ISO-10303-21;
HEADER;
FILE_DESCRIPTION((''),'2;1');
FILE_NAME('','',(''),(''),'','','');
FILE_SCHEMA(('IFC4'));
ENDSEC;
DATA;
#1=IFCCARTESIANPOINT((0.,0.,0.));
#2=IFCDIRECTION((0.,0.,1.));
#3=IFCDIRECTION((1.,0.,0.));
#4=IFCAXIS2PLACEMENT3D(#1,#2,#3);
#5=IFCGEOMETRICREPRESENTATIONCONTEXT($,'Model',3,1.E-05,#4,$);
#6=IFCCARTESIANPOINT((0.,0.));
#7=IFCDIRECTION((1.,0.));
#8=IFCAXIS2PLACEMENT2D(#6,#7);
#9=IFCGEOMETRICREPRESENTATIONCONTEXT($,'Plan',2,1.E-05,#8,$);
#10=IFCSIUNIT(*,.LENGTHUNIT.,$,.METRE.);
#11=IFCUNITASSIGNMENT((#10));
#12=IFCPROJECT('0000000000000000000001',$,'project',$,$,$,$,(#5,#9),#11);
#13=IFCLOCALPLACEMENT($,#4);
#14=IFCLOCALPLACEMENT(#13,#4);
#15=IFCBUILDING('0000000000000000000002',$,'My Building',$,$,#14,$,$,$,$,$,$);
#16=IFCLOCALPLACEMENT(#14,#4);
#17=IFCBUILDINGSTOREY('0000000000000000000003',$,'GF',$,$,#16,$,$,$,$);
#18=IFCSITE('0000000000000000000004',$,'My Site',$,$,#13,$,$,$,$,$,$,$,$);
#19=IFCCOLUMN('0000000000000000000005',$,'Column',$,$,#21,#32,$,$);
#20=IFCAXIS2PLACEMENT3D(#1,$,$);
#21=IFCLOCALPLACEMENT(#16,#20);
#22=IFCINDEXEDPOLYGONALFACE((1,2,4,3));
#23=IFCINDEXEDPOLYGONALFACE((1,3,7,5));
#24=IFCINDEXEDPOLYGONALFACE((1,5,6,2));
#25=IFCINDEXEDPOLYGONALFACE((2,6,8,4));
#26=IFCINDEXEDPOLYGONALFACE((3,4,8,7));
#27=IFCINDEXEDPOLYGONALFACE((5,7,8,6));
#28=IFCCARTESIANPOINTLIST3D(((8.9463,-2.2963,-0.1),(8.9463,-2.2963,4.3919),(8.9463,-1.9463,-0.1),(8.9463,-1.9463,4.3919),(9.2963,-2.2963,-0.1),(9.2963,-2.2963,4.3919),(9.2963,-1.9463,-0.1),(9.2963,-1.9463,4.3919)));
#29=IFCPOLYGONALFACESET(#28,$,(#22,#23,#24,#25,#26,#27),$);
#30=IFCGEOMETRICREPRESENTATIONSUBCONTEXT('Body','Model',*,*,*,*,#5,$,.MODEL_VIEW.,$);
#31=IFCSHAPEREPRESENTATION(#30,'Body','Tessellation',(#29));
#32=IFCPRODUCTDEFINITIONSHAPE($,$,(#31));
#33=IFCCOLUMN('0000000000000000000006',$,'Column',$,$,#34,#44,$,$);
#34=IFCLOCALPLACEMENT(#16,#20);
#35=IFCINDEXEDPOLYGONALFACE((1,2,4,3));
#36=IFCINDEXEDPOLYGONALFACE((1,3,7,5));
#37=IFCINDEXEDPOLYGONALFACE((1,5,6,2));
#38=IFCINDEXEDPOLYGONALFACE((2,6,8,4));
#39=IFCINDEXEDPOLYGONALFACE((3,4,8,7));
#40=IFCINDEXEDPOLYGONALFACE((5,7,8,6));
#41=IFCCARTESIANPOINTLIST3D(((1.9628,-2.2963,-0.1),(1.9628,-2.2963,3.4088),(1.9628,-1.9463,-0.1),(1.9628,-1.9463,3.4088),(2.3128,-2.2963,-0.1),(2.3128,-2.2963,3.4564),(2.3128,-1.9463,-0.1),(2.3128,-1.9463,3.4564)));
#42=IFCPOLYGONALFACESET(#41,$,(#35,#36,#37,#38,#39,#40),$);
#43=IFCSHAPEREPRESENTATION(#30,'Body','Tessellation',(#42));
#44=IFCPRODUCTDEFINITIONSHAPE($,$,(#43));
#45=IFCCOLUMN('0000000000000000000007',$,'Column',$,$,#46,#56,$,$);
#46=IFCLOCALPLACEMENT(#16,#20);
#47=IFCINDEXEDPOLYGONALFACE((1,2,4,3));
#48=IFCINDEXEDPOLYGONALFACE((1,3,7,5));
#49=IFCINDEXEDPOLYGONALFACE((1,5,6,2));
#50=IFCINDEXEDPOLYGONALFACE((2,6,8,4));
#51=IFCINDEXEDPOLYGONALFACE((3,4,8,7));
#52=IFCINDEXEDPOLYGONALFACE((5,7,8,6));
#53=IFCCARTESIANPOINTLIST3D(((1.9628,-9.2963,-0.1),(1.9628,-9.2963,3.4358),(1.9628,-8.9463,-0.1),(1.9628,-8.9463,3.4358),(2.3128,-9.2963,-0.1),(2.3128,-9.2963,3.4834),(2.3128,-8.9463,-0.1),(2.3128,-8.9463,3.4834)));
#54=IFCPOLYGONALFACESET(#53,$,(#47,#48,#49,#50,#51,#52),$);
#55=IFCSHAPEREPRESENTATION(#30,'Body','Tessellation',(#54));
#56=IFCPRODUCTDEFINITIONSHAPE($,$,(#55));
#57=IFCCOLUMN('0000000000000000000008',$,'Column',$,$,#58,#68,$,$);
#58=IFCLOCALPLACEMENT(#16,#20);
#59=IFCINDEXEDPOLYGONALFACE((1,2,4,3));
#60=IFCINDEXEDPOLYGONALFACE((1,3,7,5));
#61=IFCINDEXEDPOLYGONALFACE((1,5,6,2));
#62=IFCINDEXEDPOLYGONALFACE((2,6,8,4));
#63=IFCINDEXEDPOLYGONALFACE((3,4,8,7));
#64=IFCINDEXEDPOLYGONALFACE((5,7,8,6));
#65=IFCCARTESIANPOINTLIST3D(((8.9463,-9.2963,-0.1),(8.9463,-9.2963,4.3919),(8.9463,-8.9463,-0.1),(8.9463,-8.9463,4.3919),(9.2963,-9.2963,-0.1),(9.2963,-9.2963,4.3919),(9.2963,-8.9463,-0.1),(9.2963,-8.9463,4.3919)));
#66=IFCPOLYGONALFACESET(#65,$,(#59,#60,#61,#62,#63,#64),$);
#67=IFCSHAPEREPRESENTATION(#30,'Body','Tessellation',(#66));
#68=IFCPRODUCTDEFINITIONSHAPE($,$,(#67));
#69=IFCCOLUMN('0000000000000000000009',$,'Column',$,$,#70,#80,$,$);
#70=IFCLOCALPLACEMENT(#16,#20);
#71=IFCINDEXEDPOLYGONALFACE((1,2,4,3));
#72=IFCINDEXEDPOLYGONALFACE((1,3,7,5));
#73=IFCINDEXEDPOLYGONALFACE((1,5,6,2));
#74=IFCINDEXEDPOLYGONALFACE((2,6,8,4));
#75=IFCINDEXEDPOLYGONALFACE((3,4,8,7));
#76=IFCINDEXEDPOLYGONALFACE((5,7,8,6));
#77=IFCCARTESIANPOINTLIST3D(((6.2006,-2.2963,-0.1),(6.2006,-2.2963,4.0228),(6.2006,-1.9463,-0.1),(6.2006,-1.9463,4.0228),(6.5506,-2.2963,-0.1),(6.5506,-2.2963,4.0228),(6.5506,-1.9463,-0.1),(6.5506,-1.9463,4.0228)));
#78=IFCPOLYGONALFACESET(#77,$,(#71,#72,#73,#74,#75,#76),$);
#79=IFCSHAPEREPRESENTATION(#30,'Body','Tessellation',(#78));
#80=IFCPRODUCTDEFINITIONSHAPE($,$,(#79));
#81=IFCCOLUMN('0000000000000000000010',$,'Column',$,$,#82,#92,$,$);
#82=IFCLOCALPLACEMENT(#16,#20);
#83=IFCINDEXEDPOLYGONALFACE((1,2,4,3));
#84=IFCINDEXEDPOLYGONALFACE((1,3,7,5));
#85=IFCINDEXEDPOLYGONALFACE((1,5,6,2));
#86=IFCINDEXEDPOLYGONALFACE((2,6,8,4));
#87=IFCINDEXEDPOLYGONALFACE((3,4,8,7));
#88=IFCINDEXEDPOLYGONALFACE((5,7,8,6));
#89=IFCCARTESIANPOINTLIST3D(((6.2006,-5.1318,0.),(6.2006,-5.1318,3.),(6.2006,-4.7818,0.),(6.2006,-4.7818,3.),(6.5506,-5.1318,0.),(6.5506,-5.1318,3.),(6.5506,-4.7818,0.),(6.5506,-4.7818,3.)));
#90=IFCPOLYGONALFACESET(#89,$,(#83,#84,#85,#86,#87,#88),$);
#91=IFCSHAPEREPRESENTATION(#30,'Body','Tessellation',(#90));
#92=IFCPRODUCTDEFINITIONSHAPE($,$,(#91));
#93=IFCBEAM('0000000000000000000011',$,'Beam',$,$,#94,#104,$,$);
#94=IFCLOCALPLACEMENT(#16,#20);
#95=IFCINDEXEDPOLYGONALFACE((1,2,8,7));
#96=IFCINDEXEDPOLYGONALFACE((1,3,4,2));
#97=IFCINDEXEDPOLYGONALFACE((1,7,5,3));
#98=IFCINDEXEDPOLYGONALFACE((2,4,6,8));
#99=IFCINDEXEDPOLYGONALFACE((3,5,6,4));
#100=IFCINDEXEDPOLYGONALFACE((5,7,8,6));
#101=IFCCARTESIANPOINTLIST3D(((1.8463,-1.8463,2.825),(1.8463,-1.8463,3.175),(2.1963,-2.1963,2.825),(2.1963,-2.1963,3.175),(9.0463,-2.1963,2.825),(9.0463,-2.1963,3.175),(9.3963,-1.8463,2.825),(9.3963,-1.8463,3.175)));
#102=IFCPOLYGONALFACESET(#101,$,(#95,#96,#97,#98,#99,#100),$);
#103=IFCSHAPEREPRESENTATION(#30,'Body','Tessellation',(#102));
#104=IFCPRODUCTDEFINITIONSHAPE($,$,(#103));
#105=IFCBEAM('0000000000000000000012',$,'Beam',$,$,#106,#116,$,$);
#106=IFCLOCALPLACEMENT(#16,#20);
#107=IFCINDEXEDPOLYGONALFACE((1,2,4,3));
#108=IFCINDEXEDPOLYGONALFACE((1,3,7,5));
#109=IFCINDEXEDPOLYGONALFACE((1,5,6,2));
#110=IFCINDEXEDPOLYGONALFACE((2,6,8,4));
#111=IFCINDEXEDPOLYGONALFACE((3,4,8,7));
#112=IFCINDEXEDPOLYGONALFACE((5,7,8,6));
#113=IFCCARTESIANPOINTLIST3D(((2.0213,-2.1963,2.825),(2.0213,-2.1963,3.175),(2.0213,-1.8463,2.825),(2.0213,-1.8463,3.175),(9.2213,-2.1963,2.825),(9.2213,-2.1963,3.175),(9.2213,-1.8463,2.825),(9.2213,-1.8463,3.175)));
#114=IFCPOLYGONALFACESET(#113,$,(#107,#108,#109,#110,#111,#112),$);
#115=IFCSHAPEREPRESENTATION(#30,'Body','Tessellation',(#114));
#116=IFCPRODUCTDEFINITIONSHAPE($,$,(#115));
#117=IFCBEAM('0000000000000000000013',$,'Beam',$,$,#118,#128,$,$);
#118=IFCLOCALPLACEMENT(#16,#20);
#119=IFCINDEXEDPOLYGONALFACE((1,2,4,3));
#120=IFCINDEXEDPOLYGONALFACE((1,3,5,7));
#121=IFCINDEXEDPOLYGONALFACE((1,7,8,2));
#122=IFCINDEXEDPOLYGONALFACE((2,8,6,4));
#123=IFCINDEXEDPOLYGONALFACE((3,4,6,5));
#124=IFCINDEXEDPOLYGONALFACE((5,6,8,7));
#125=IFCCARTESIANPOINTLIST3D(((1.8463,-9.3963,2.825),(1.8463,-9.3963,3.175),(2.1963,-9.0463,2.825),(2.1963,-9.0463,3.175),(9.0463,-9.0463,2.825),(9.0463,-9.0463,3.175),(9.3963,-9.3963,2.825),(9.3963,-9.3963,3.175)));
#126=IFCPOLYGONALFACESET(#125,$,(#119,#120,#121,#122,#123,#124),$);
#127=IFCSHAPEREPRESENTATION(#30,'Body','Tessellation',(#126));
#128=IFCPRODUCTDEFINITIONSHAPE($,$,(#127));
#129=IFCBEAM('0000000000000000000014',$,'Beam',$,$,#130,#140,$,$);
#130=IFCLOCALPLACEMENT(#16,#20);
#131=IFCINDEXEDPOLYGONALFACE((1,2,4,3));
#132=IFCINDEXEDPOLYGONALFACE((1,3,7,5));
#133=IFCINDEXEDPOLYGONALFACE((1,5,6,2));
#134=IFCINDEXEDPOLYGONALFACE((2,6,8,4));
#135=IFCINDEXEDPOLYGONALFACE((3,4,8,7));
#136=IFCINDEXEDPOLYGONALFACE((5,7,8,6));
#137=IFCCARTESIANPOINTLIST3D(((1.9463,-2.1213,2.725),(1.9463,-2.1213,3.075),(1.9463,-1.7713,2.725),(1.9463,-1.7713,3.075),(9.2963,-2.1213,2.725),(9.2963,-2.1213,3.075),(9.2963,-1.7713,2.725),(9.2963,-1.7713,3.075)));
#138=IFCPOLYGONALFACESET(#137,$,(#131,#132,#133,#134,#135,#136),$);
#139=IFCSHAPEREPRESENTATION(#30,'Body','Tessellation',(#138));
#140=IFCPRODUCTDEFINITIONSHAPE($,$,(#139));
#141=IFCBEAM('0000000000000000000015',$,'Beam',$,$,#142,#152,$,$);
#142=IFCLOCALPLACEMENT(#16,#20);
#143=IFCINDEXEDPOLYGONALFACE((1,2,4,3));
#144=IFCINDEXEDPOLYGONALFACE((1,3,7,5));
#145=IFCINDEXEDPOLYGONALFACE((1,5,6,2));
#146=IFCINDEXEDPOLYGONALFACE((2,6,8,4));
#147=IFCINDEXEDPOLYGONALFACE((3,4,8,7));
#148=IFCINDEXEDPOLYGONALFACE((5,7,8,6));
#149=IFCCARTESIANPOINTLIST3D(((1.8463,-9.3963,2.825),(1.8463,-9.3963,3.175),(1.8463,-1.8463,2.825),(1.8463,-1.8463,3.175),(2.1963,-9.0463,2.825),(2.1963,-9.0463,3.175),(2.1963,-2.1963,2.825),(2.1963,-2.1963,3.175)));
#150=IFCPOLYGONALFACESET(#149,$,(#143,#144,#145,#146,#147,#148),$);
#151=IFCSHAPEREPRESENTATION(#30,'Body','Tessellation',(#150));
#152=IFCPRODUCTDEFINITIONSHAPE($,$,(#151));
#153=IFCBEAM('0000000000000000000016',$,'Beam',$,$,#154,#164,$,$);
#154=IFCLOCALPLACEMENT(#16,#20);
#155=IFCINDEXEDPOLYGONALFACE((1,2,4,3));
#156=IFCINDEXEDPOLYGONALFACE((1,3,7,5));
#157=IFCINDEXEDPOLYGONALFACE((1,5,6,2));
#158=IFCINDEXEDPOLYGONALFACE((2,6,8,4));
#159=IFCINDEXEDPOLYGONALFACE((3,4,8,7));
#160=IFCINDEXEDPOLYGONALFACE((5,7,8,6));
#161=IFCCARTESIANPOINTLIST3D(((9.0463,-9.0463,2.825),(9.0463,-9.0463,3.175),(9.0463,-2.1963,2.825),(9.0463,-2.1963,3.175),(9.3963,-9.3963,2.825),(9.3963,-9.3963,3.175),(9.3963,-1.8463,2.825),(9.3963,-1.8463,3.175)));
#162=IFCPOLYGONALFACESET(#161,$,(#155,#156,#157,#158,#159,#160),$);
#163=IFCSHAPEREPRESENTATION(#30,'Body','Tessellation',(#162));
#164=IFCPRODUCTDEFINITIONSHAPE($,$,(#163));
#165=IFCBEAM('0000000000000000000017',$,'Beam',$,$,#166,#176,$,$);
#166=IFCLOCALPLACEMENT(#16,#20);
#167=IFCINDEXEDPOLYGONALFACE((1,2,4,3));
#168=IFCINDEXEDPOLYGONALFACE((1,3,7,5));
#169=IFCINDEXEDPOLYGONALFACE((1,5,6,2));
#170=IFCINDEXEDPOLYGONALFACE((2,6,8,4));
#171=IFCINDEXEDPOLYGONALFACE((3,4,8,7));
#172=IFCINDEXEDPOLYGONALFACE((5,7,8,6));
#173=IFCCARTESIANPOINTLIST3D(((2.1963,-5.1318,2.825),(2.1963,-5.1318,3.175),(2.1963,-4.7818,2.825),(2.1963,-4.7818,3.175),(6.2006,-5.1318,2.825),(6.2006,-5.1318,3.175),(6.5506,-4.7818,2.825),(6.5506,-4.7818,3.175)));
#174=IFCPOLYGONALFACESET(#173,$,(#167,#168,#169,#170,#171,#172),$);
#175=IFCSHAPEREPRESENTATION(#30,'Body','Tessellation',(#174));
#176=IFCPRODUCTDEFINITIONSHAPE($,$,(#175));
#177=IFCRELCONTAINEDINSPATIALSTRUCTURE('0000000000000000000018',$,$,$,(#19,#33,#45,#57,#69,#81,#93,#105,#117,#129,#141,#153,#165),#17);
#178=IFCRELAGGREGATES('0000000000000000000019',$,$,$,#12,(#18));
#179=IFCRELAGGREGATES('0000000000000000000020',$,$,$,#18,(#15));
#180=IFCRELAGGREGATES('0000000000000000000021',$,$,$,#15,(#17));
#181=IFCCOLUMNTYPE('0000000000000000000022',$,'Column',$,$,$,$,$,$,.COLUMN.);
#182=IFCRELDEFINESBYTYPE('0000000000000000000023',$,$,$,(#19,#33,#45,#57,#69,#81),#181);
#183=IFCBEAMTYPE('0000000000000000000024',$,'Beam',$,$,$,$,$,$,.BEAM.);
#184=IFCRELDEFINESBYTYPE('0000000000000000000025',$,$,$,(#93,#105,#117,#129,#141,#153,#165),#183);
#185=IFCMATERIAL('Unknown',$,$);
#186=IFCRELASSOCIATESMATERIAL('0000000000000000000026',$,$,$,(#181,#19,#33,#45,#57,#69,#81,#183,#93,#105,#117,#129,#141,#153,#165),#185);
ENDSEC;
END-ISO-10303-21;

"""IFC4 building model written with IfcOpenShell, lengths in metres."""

from ifc_helpers import new_model, si_unit, frame, origin_with_axes, origin_2d_with_axis, place, context, subcontext, project, spatial, rectangle, extrude, clip, halfspace, material, material_profile, profile_set, profile_usage, type_object, element, save


model = new_model("IFC4")

# Units and contexts
model_context = context("Model", 3, precision=1e-05, world=origin_with_axes())
plan_context = context("Plan", 2, precision=1e-05, world=origin_2d_with_axis())
body_context_1 = subcontext(model_context, "Body", "Model", "MODEL_VIEW")
ifc_project = project(units=[si_unit("LENGTHUNIT", "METRE")], contexts=[model_context, plan_context])

# Site, building, storey
site_placement = place(None, origin_with_axes())
site = spatial("IfcSite", under=ifc_project, at=site_placement, Name="My Site")
building_placement = place(site_placement, origin_with_axes())
building = spatial("IfcBuilding", under=site, at=building_placement, Name="My Building")
storey_placement = place(building_placement, origin_with_axes())
storey = spatial("IfcBuildingStorey", under=building, at=storey_placement, Name="GF")

# Columns
ifc_material = material(Name="Unknown")
ifc_material_profile_1 = material_profile(ifc_material, rectangle(XDim=0.35, YDim=0.35))
ifc_profile_set_1 = profile_set([ifc_material_profile_1])
ifc_profile_usage_1 = profile_usage(ifc_profile_set_1, cardinal=5)
column_type = type_object("IfcColumnType", Name="Column", PredefinedType="COLUMN", material=ifc_profile_set_1)
column_1_placement = place(storey_placement, frame((9.1213, -2.1213, -0.1), z_axis=(0.0, 0.0, 1.0), x_axis=(1.0, 0.0, 0.0)))
element("IfcColumn", 1, at=column_1_placement, inside=storey, type_object=column_type, material=ifc_profile_usage_1, Name="Column", context=body_context_1, shape_type="SweptSolid", body=[
    extrude(rectangle(XDim=0.35, YDim=0.35), origin_with_axes(), (0.0, 0.0, 1.0), 4.4919),
])
ifc_profile_usage_2 = profile_usage(ifc_profile_set_1, cardinal=5)
column_2_placement = place(storey_placement, frame((2.1378, -2.1213, -0.1), z_axis=(0.0, 0.0, 1.0), x_axis=(1.0, 0.0, 0.0)))
element("IfcColumn", 2, at=column_2_placement, inside=storey, type_object=column_type, material=ifc_profile_usage_2, Name="Column", context=body_context_1, shape_type="Clipping", body=[
    clip(extrude(rectangle(XDim=0.35, YDim=0.35), origin_with_axes(), (0.0, 0.0, 1.0), 3.8826), halfspace(frame((6.8081, 0.0, 4.4568), z_axis=(-0.134523, 0.0, 0.990911), x_axis=(0.0, 1.0, 0.0)), False)),
])
ifc_profile_usage_3 = profile_usage(ifc_profile_set_1, cardinal=5)
column_3_placement = place(storey_placement, frame((2.1378, -9.1213, -0.1), z_axis=(0.0, 0.0, 1.0), x_axis=(1.0, 0.0, 0.0)))
element("IfcColumn", 3, at=column_3_placement, inside=storey, type_object=column_type, material=ifc_profile_usage_3, Name="Column", context=body_context_1, shape_type="Clipping", body=[
    clip(extrude(rectangle(XDim=0.35, YDim=0.35), origin_with_axes(), (0.0, 0.0, 1.0), 3.9096), halfspace(frame((6.8081, 0.0, 4.4838), z_axis=(-0.134523, 0.0, 0.990911), x_axis=(0.0, 1.0, 0.0)), False)),
])
ifc_profile_usage_4 = profile_usage(ifc_profile_set_1, cardinal=5)
column_4_placement = place(storey_placement, frame((9.1213, -9.1213, -0.1), z_axis=(0.0, 0.0, 1.0), x_axis=(1.0, 0.0, 0.0)))
element("IfcColumn", 4, at=column_4_placement, inside=storey, type_object=column_type, material=ifc_profile_usage_4, Name="Column", context=body_context_1, shape_type="SweptSolid", body=[
    extrude(rectangle(XDim=0.35, YDim=0.35), origin_with_axes(), (0.0, 0.0, 1.0), 4.4919),
])
ifc_profile_usage_5 = profile_usage(ifc_profile_set_1, cardinal=5)
column_5_placement = place(storey_placement, frame((6.3756, -2.1213, -0.1), z_axis=(0.0, 0.0, 1.0), x_axis=(1.0, 0.0, 0.0)))
element("IfcColumn", 5, at=column_5_placement, inside=storey, type_object=column_type, material=ifc_profile_usage_5, Name="Column", context=body_context_1, shape_type="SweptSolid", body=[
    extrude(rectangle(XDim=0.35, YDim=0.35), origin_with_axes(), (0.0, 0.0, 1.0), 4.1228),
])
ifc_profile_usage_6 = profile_usage(ifc_profile_set_1, cardinal=5)
column_6_placement = place(storey_placement, frame((6.3756, -4.9568, 0.0), z_axis=(0.0, 0.0, 1.0), x_axis=(1.0, 0.0, 0.0)))
element("IfcColumn", 6, at=column_6_placement, inside=storey, type_object=column_type, material=ifc_profile_usage_6, Name="Column", context=body_context_1, shape_type="SweptSolid", body=[
    extrude(rectangle(XDim=0.35, YDim=0.35), origin_with_axes(), (0.0, 0.0, 1.0), 3.0),
])

# Beams
ifc_material_profile_2 = material_profile(ifc_material, rectangle(XDim=0.35, YDim=0.35))
ifc_profile_set_2 = profile_set([ifc_material_profile_2])
ifc_profile_usage_7 = profile_usage(ifc_profile_set_2, cardinal=5)
beam_type = type_object("IfcBeamType", Name="Beam", PredefinedType="BEAM", material=ifc_profile_set_2)
beam_1_placement = place(storey_placement, frame((9.3963, -2.0213, 3.0), z_axis=(-1.0, 0.0, 0.0), x_axis=(0.0, -1.0, 0.0)))
element("IfcBeam", 7, at=beam_1_placement, inside=storey, type_object=beam_type, material=ifc_profile_usage_7, Name="Beam", context=body_context_1, shape_type="Clipping", body=[
    clip(clip(extrude(rectangle(XDim=0.35, YDim=0.35), origin_with_axes(), (0.0, 0.0, 1.0), 7.55), halfspace(frame((-0.175, -3.0, 7.55), z_axis=(0.707108, 0.0, 0.707106), x_axis=(0.0, -1.0, 0.0)), False)), halfspace(frame((-0.175, -3.0, 0.0), z_axis=(0.707107, 0.0, -0.707106), x_axis=(0.0, -1.0, 0.0)), False)),
])
ifc_profile_usage_8 = profile_usage(ifc_profile_set_2, cardinal=5)
beam_2_placement = place(storey_placement, frame((9.2213, -2.0213, 3.0), z_axis=(-1.0, 0.0, 0.0), x_axis=(0.0, -1.0, 0.0)))
element("IfcBeam", 8, at=beam_2_placement, inside=storey, type_object=beam_type, material=ifc_profile_usage_8, Name="Beam", context=body_context_1, shape_type="SweptSolid", body=[
    extrude(rectangle(XDim=0.35, YDim=0.35), origin_with_axes(), (0.0, 0.0, 1.0), 7.2),
])
ifc_profile_usage_9 = profile_usage(ifc_profile_set_2, cardinal=5)
beam_3_placement = place(storey_placement, frame((1.8463, -9.2213, 3.0), z_axis=(1.0, 0.0, 0.0), x_axis=(0.0, 1.0, 0.0)))
element("IfcBeam", 9, at=beam_3_placement, inside=storey, type_object=beam_type, material=ifc_profile_usage_9, Name="Beam", context=body_context_1, shape_type="Clipping", body=[
    clip(clip(extrude(rectangle(XDim=0.35, YDim=0.35), origin_with_axes(), (0.0, 0.0, 1.0), 7.55), halfspace(frame((-0.175, -3.0, 7.55), z_axis=(0.707106, 0.0, 0.707107), x_axis=(0.0, -1.0, 0.0)), False)), halfspace(frame((-0.175, -3.0, 0.0), z_axis=(0.707105, 0.0, -0.707109), x_axis=(0.0, -1.0, 0.0)), False)),
])
ifc_profile_usage_10 = profile_usage(ifc_profile_set_2, cardinal=5)
beam_4_placement = place(storey_placement, frame((1.9463, -1.9463, 2.9), z_axis=(1.0, 0.0, 0.0), x_axis=(0.0, 1.0, 0.0)))
element("IfcBeam", 10, at=beam_4_placement, inside=storey, type_object=beam_type, material=ifc_profile_usage_10, Name="Beam", context=body_context_1, shape_type="SweptSolid", body=[
    extrude(rectangle(XDim=0.35, YDim=0.35), origin_with_axes(), (0.0, 0.0, 1.0), 7.35),
])
ifc_profile_usage_11 = profile_usage(ifc_profile_set_2, cardinal=5)
beam_5_placement = place(storey_placement, frame((2.0213, -9.3963, 3.0), z_axis=(-0.000003, 1.0, 0.0), x_axis=(-1.0, -0.000003, 0.0)))
element("IfcBeam", 11, at=beam_5_placement, inside=storey, type_object=beam_type, material=ifc_profile_usage_11, Name="Beam", context=body_context_1, shape_type="Clipping", body=[
    clip(clip(extrude(rectangle(XDim=0.35, YDim=0.35), origin_with_axes(), (0.0, 0.0, 1.0), 7.55), halfspace(frame((0.175, -3.0, 0.0), z_axis=(-0.707107, 0.0, -0.707107), x_axis=(0.0, 1.0, 0.0)), False)), halfspace(frame((0.175, -3.0, 7.55), z_axis=(-0.707108, 0.0, 0.707106), x_axis=(0.0, 1.0, 0.0)), False)),
])
ifc_profile_usage_12 = profile_usage(ifc_profile_set_2, cardinal=5)
beam_6_placement = place(storey_placement, frame((9.2213, -9.3963, 3.0), z_axis=(0.0, 1.0, 0.0), x_axis=(-1.0, 0.0, 0.0)))
element("IfcBeam", 12, at=beam_6_placement, inside=storey, type_object=beam_type, material=ifc_profile_usage_12, Name="Beam", context=body_context_1, shape_type="Clipping", body=[
    clip(clip(extrude(rectangle(XDim=0.35, YDim=0.35), origin_with_axes(), (0.0, 0.0, 1.0), 7.55), halfspace(frame((-0.175, -3.0, 7.55), z_axis=(0.707106, 0.0, 0.707107), x_axis=(0.0, -1.0, 0.0)), False)), halfspace(frame((-0.175, -3.0, 0.0), z_axis=(0.707108, 0.0, -0.707106), x_axis=(0.0, -1.0, 0.0)), False)),
])
ifc_profile_usage_13 = profile_usage(ifc_profile_set_2, cardinal=5)
beam_7_placement = place(storey_placement, frame((6.5506, -4.9568, 3.0), z_axis=(-1.0, 0.0, 0.0), x_axis=(0.0, -1.0, 0.0)))
element("IfcBeam", 13, at=beam_7_placement, inside=storey, type_object=beam_type, material=ifc_profile_usage_13, Name="Beam", context=body_context_1, shape_type="Clipping", body=[
    clip(extrude(rectangle(XDim=0.35, YDim=0.35), origin_with_axes(), (0.0, 0.0, 1.0), 4.3543), halfspace(frame((-0.175, -3.0, 0.0), z_axis=(0.707107, 0.0, -0.707107), x_axis=(0.0, -1.0, 0.0)), False)),
])

save(model, "model.ifc")
